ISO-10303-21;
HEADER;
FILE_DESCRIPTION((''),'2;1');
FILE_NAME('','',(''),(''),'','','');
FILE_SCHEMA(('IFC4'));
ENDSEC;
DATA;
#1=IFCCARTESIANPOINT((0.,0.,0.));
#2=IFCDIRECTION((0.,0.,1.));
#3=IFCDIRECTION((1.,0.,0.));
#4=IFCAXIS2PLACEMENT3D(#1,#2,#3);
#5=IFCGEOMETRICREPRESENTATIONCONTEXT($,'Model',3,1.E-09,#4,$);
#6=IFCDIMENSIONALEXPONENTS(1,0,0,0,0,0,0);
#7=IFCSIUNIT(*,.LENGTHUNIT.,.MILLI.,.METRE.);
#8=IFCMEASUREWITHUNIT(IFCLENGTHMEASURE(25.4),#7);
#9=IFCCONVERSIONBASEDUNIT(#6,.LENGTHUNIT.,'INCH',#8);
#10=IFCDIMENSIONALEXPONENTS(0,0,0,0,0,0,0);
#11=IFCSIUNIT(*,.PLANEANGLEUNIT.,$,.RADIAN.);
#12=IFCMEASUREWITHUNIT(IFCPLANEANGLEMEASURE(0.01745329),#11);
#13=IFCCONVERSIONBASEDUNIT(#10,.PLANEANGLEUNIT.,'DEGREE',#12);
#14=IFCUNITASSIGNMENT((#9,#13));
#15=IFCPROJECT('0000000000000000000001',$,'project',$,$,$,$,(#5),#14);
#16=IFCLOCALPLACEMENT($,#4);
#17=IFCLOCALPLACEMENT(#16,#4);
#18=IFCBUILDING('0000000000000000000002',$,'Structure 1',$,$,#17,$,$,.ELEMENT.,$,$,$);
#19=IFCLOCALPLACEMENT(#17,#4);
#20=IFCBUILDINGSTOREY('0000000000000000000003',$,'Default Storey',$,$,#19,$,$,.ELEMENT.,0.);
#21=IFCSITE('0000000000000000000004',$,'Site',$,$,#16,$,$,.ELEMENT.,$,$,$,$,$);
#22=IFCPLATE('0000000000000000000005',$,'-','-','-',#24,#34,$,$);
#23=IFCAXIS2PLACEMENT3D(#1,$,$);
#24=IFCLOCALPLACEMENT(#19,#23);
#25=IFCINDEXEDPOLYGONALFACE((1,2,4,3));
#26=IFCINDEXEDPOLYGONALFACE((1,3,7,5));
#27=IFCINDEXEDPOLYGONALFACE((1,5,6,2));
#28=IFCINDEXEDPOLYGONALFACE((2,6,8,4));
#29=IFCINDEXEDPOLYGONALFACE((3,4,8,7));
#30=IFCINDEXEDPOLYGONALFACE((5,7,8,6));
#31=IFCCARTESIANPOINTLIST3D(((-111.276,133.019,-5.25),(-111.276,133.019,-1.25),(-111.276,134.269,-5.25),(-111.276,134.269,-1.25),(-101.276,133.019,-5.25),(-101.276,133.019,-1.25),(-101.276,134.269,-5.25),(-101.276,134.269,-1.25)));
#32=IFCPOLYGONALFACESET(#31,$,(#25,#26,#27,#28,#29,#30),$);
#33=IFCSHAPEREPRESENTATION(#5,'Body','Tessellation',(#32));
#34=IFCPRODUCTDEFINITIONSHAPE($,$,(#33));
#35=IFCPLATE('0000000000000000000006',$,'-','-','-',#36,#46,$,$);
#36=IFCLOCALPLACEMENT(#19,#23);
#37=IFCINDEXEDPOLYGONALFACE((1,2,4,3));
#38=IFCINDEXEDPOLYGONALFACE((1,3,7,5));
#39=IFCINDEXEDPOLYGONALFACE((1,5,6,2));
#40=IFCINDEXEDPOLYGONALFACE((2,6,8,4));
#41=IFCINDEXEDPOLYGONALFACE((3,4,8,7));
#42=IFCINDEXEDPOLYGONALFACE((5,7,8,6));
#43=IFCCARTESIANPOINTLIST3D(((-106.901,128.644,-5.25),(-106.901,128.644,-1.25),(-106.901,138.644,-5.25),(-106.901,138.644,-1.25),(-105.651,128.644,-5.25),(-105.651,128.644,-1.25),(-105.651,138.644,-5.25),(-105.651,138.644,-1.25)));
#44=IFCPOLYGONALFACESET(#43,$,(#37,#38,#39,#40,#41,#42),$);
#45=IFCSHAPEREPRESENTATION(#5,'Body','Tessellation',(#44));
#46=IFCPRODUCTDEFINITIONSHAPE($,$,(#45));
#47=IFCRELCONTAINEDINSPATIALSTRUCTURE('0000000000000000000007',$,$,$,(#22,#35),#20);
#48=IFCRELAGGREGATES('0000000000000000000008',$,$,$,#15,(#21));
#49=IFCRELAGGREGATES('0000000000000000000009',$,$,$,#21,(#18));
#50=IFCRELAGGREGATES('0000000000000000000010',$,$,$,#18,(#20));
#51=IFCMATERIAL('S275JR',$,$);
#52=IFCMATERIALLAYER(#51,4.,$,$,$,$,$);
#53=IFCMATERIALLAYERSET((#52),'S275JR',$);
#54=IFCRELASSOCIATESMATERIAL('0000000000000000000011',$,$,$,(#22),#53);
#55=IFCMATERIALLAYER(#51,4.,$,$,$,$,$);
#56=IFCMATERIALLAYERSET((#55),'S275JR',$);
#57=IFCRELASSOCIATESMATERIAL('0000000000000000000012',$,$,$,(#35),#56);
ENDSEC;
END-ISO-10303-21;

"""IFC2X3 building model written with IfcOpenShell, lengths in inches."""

from ifc_helpers import new_model, entity, si_unit, converted_unit, frame, origin_with_axes, place, context, project, spatial, polyline, outline, extrude, material, layer, layer_set, element, save


model = new_model("IFC2X3")

# Units and contexts
model_context = context("Model", 3, precision=1e-09, world=origin_with_axes())
ifc_project = project(units=[converted_unit("LENGTHUNIT", "INCH", entity("IfcLengthMeasure", 25.4), si_unit("LENGTHUNIT", "METRE", prefix="MILLI"), dimensions=[1, 0, 0, 0, 0, 0, 0]), converted_unit("PLANEANGLEUNIT", "DEGREE", entity("IfcPlaneAngleMeasure", 0.01745329), si_unit("PLANEANGLEUNIT", "RADIAN"), dimensions=[0, 0, 0, 0, 0, 0, 0])], contexts=[model_context])

# Site, building, storey
site_placement = place(None, origin_with_axes())
site = spatial("IfcSite", under=ifc_project, at=site_placement, Name="Site", CompositionType="ELEMENT")
building_placement = place(site_placement, origin_with_axes())
building = spatial("IfcBuilding", under=site, at=building_placement, Name="Structure 1", CompositionType="ELEMENT")
storey_placement = place(building_placement, origin_with_axes())
storey = spatial("IfcBuildingStorey", under=building, at=storey_placement, Name="Default Storey", CompositionType="ELEMENT", Elevation=0.0)

# Plates
ifc_material_1 = material(Name="S275JR")
ifc_layer_1 = layer(ifc_material_1, 4.0)
ifc_layer_set_1 = layer_set([ifc_layer_1], Name="S275JR")
plate_1_placement = place(None, frame((-106.276, 133.644, -5.25), z_axis=(0.0, 0.0, 1.0), x_axis=(0.0, -1.0, 0.0)))
element("IfcPlate", 1, at=plate_1_placement, inside=storey, material=ifc_layer_set_1, Name="-", Description="-", ObjectType="-", context=model_context, shape_type="SweptSolid", body=[
    extrude(outline(polyline([(-0.625, -5.0), (0.625, -5.0), (0.625, 5.0), (-0.625, 5.0), (-0.625, -5.0)])), origin_with_axes(), (0.0, 0.0, 1.0), 4.0),
])
ifc_layer_2 = layer(ifc_material_1, 4.0)
ifc_layer_set_2 = layer_set([ifc_layer_2], Name="S275JR")
plate_2_placement = place(None, frame((-106.276, 133.644, -5.25), z_axis=(0.0, 0.0, 1.0), x_axis=(1.0, 0.0, 0.0)))
element("IfcPlate", 2, at=plate_2_placement, inside=storey, material=ifc_layer_set_2, Name="-", Description="-", ObjectType="-", context=model_context, shape_type="SweptSolid", body=[
    extrude(outline(polyline([(-0.625, -5.0), (0.625, -5.0), (0.625, 5.0), (-0.625, 5.0), (-0.625, -5.0)])), origin_with_axes(), (0.0, 0.0, 1.0), 4.0),
])

save(model, "model.ifc")
